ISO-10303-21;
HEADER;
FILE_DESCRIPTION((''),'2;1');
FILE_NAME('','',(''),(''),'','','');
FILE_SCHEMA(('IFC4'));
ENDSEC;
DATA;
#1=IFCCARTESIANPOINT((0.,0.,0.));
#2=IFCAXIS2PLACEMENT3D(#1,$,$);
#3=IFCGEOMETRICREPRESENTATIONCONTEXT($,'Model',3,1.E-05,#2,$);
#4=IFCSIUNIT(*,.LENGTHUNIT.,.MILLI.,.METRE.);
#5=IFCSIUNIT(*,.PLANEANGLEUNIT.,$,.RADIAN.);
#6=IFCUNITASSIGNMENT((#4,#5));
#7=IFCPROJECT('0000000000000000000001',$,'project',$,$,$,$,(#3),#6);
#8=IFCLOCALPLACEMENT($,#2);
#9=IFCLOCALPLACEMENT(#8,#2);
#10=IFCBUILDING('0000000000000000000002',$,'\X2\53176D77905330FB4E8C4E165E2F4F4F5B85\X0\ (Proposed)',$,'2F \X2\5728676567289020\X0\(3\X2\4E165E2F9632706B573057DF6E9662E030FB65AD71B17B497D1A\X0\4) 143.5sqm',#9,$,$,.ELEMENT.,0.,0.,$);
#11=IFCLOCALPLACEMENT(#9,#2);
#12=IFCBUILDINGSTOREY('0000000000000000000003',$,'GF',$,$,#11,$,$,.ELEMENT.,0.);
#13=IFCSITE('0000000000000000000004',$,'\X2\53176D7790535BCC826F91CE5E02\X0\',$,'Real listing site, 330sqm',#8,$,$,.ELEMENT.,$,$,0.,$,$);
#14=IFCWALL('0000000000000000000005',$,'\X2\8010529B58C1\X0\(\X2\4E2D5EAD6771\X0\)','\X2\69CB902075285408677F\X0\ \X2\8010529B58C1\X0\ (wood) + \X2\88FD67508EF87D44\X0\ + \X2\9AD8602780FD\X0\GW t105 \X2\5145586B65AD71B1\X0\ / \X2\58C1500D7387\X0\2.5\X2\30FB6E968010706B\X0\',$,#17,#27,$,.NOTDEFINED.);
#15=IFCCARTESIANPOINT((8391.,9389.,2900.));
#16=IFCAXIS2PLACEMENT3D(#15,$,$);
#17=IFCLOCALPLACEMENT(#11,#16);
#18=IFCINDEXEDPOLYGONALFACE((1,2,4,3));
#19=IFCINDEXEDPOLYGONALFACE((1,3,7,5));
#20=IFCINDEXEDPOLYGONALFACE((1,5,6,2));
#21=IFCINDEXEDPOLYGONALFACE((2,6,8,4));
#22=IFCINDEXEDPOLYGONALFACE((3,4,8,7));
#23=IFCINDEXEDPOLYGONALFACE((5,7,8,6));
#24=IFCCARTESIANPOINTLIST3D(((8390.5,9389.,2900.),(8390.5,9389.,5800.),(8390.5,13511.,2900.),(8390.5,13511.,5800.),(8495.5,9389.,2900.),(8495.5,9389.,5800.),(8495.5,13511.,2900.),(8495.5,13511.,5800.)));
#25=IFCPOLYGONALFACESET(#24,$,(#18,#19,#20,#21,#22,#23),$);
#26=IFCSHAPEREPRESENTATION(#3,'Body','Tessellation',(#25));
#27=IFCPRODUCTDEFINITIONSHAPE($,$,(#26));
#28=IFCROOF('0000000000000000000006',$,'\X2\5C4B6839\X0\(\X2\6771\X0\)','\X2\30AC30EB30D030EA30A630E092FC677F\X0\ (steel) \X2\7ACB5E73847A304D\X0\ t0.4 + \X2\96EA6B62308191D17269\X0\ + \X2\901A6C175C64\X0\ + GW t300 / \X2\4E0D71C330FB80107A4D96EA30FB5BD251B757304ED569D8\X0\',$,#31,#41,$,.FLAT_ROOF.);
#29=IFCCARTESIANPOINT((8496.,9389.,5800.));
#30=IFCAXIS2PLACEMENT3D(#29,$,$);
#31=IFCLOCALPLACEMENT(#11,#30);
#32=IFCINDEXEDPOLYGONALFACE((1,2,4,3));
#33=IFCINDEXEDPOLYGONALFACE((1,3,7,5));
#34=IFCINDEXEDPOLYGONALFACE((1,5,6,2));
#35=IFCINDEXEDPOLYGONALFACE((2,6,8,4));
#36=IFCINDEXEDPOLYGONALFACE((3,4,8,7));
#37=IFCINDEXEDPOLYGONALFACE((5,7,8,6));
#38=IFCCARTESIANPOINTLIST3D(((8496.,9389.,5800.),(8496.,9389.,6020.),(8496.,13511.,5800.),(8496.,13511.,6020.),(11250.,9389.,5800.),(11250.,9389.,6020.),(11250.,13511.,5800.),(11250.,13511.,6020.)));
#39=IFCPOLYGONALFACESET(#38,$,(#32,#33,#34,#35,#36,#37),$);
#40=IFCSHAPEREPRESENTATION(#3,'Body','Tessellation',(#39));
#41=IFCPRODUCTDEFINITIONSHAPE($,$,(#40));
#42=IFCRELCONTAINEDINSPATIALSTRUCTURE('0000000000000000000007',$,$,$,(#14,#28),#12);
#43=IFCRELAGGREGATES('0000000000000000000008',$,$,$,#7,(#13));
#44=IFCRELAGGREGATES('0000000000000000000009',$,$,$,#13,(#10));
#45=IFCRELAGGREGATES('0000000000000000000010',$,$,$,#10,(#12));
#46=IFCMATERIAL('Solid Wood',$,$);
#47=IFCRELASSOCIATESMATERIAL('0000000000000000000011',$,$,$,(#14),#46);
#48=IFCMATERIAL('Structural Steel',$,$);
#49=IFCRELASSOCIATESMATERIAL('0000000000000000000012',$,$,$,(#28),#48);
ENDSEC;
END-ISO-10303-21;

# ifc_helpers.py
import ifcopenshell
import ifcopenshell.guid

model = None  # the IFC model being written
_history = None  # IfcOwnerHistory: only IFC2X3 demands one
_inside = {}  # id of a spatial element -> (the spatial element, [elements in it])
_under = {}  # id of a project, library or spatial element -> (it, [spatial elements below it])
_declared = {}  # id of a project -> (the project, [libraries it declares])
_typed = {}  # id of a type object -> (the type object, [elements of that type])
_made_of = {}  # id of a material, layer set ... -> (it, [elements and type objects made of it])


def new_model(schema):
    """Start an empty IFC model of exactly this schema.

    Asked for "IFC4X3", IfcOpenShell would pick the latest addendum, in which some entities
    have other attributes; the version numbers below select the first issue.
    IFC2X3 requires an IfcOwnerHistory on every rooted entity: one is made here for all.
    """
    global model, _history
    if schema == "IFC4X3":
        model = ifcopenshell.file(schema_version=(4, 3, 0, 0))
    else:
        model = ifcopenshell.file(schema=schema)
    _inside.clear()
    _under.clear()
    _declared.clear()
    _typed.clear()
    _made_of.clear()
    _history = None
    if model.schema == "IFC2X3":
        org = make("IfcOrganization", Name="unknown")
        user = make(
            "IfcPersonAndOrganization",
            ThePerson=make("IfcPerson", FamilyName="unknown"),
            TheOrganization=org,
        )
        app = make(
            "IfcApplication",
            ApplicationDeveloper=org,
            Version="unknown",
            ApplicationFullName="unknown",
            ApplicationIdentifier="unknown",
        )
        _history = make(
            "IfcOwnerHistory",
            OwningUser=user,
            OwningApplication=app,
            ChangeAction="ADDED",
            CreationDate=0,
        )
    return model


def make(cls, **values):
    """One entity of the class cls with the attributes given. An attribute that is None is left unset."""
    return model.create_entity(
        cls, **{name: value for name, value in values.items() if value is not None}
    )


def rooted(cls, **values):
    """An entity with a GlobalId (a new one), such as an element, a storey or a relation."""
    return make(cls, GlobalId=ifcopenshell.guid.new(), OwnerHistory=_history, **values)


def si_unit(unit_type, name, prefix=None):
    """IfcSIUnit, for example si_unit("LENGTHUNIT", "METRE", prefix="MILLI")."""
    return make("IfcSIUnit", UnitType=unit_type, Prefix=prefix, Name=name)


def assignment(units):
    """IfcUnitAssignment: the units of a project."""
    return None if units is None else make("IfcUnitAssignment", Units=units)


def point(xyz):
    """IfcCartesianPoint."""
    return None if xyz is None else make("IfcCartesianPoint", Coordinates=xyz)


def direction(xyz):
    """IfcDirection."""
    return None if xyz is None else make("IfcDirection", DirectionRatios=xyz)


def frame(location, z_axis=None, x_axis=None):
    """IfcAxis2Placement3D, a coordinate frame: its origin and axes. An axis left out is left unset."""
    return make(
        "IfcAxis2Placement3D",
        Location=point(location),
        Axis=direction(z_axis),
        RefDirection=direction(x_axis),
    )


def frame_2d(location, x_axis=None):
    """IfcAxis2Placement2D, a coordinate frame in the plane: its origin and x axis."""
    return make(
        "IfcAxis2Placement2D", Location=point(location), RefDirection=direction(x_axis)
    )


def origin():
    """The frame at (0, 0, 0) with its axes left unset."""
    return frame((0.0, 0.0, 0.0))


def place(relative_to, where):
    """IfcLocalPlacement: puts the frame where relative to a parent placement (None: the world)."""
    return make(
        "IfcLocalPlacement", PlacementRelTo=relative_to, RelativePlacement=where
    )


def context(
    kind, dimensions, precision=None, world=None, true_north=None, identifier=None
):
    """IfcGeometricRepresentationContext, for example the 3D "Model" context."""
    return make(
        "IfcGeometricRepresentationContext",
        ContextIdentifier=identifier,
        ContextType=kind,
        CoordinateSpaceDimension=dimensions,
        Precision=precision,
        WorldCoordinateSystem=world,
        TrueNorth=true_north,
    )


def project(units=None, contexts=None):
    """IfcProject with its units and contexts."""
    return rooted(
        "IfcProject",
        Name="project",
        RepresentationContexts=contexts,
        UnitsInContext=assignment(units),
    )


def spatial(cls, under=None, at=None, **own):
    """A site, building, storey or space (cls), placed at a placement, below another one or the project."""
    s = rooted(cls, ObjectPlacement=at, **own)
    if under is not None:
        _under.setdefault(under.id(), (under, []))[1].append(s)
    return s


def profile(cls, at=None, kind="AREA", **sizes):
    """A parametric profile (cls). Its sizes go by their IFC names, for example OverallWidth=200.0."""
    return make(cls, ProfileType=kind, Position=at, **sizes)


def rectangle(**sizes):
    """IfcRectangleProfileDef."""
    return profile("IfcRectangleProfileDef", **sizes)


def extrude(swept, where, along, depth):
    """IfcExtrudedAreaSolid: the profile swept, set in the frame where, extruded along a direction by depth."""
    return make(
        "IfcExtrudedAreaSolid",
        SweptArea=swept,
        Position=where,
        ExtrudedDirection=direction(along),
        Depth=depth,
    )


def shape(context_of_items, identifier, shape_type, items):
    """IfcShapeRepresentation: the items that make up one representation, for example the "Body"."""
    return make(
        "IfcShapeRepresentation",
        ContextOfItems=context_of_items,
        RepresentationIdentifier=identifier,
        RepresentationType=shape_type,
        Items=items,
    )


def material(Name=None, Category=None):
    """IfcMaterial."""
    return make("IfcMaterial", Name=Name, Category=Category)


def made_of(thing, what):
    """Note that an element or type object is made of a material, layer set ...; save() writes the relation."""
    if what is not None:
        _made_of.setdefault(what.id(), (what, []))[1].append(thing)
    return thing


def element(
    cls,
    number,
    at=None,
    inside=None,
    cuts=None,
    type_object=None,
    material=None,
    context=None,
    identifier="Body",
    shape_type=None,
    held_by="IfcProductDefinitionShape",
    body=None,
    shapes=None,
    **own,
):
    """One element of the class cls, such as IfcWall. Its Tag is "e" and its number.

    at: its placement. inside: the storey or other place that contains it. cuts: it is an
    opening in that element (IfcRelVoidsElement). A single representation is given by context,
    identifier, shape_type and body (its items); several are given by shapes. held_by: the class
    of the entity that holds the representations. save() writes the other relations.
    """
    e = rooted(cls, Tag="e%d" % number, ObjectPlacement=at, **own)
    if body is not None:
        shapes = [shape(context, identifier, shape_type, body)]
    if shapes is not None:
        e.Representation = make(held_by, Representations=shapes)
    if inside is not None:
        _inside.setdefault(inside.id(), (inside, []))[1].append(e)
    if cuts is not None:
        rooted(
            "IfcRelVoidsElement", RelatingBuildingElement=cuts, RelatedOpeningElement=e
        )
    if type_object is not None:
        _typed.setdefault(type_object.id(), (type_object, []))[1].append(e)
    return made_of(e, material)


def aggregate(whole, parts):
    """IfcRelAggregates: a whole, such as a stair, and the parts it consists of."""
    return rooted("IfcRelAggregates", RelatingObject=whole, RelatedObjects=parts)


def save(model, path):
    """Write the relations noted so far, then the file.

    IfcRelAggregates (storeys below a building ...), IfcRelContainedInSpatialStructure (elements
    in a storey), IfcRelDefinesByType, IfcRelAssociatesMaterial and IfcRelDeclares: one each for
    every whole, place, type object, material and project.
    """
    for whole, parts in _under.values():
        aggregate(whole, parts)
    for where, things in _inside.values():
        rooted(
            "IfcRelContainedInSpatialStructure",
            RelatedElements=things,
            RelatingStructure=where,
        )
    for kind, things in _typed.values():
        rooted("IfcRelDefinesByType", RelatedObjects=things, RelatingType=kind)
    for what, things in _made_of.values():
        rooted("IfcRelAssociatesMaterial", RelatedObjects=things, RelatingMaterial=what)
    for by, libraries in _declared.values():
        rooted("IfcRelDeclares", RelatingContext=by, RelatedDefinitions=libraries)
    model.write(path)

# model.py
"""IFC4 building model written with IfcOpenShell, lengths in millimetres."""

from ifc_helpers import new_model, si_unit, frame, frame_2d, origin, place, context, project, spatial, rectangle, extrude, material, element, save


model = new_model("IFC4")

# Units and contexts
model_context = context("Model", 3, precision=1e-05, world=origin())
ifc_project = project(units=[si_unit("LENGTHUNIT", "METRE", prefix="MILLI"), si_unit("PLANEANGLEUNIT", "RADIAN")], contexts=[model_context])

# Site, building, storey
site_placement = place(None, origin())
site = spatial("IfcSite", under=ifc_project, at=site_placement, Name="北海道富良野市", ObjectType="Real listing site, 330sqm", CompositionType="ELEMENT", RefElevation=0.0)
building_placement = place(site_placement, origin())
building = spatial("IfcBuilding", under=site, at=building_placement, Name="北海道・二世帯住宅 (Proposed)", ObjectType="2F 在来木造(3世帯防火地域準拠・断熱等級4) 143.5sqm", CompositionType="ELEMENT", ElevationOfRefHeight=0.0, ElevationOfTerrain=0.0)
storey_placement = place(building_placement, origin())
storey = spatial("IfcBuildingStorey", under=building, at=storey_placement, Name="GF", CompositionType="ELEMENT", Elevation=0.0)

# Shared definitions
ifc_material_1 = material(Name="Solid Wood")

# Wall
wall_1_placement = place(storey_placement, frame((8391.0, 9389.0, 2900.0)))
element("IfcWall", 1, at=wall_1_placement, inside=storey, material=ifc_material_1, Name="耐力壁(中庭東)", Description="構造用合板 耐力壁 (wood) + 製材軸組 + 高性能GW t105 充填断熱 / 壁倍率2.5・準耐火", PredefinedType="NOTDEFINED", context=model_context, shape_type="SweptSolid", body=[
    extrude(rectangle(XDim=105.0, YDim=4122.0, at=frame_2d((52.0, 2061.0))), frame((8391.0, 9389.0, 2900.0)), (0.0, 0.0, 1.0), 2900.0),
])

# Roof
ifc_material_2 = material(Name="Structural Steel")
for number, where, name in (
    (2, (8496.0, 9389.0, 5800.0), "屋根(東)"),
):
    element("IfcRoof", number, at=place(storey_placement, frame(where)), inside=storey, material=ifc_material_2, Name=name, Description="ガルバリウム鋼板 (steel) 立平葺き t0.4 + 雪止め金物 + 通気層 + GW t300 / 不燃・耐積雪・寒冷地仕様", PredefinedType="FLAT_ROOF", context=model_context, shape_type="SweptSolid", body=[
        extrude(rectangle(XDim=2754.0, YDim=4122.0, at=frame_2d((1377.0, 2061.0))), frame((8496.0, 9389.0, 5800.0)), (0.0, 0.0, 1.0), 220.0),
    ])

save(model, "model.ifc")
